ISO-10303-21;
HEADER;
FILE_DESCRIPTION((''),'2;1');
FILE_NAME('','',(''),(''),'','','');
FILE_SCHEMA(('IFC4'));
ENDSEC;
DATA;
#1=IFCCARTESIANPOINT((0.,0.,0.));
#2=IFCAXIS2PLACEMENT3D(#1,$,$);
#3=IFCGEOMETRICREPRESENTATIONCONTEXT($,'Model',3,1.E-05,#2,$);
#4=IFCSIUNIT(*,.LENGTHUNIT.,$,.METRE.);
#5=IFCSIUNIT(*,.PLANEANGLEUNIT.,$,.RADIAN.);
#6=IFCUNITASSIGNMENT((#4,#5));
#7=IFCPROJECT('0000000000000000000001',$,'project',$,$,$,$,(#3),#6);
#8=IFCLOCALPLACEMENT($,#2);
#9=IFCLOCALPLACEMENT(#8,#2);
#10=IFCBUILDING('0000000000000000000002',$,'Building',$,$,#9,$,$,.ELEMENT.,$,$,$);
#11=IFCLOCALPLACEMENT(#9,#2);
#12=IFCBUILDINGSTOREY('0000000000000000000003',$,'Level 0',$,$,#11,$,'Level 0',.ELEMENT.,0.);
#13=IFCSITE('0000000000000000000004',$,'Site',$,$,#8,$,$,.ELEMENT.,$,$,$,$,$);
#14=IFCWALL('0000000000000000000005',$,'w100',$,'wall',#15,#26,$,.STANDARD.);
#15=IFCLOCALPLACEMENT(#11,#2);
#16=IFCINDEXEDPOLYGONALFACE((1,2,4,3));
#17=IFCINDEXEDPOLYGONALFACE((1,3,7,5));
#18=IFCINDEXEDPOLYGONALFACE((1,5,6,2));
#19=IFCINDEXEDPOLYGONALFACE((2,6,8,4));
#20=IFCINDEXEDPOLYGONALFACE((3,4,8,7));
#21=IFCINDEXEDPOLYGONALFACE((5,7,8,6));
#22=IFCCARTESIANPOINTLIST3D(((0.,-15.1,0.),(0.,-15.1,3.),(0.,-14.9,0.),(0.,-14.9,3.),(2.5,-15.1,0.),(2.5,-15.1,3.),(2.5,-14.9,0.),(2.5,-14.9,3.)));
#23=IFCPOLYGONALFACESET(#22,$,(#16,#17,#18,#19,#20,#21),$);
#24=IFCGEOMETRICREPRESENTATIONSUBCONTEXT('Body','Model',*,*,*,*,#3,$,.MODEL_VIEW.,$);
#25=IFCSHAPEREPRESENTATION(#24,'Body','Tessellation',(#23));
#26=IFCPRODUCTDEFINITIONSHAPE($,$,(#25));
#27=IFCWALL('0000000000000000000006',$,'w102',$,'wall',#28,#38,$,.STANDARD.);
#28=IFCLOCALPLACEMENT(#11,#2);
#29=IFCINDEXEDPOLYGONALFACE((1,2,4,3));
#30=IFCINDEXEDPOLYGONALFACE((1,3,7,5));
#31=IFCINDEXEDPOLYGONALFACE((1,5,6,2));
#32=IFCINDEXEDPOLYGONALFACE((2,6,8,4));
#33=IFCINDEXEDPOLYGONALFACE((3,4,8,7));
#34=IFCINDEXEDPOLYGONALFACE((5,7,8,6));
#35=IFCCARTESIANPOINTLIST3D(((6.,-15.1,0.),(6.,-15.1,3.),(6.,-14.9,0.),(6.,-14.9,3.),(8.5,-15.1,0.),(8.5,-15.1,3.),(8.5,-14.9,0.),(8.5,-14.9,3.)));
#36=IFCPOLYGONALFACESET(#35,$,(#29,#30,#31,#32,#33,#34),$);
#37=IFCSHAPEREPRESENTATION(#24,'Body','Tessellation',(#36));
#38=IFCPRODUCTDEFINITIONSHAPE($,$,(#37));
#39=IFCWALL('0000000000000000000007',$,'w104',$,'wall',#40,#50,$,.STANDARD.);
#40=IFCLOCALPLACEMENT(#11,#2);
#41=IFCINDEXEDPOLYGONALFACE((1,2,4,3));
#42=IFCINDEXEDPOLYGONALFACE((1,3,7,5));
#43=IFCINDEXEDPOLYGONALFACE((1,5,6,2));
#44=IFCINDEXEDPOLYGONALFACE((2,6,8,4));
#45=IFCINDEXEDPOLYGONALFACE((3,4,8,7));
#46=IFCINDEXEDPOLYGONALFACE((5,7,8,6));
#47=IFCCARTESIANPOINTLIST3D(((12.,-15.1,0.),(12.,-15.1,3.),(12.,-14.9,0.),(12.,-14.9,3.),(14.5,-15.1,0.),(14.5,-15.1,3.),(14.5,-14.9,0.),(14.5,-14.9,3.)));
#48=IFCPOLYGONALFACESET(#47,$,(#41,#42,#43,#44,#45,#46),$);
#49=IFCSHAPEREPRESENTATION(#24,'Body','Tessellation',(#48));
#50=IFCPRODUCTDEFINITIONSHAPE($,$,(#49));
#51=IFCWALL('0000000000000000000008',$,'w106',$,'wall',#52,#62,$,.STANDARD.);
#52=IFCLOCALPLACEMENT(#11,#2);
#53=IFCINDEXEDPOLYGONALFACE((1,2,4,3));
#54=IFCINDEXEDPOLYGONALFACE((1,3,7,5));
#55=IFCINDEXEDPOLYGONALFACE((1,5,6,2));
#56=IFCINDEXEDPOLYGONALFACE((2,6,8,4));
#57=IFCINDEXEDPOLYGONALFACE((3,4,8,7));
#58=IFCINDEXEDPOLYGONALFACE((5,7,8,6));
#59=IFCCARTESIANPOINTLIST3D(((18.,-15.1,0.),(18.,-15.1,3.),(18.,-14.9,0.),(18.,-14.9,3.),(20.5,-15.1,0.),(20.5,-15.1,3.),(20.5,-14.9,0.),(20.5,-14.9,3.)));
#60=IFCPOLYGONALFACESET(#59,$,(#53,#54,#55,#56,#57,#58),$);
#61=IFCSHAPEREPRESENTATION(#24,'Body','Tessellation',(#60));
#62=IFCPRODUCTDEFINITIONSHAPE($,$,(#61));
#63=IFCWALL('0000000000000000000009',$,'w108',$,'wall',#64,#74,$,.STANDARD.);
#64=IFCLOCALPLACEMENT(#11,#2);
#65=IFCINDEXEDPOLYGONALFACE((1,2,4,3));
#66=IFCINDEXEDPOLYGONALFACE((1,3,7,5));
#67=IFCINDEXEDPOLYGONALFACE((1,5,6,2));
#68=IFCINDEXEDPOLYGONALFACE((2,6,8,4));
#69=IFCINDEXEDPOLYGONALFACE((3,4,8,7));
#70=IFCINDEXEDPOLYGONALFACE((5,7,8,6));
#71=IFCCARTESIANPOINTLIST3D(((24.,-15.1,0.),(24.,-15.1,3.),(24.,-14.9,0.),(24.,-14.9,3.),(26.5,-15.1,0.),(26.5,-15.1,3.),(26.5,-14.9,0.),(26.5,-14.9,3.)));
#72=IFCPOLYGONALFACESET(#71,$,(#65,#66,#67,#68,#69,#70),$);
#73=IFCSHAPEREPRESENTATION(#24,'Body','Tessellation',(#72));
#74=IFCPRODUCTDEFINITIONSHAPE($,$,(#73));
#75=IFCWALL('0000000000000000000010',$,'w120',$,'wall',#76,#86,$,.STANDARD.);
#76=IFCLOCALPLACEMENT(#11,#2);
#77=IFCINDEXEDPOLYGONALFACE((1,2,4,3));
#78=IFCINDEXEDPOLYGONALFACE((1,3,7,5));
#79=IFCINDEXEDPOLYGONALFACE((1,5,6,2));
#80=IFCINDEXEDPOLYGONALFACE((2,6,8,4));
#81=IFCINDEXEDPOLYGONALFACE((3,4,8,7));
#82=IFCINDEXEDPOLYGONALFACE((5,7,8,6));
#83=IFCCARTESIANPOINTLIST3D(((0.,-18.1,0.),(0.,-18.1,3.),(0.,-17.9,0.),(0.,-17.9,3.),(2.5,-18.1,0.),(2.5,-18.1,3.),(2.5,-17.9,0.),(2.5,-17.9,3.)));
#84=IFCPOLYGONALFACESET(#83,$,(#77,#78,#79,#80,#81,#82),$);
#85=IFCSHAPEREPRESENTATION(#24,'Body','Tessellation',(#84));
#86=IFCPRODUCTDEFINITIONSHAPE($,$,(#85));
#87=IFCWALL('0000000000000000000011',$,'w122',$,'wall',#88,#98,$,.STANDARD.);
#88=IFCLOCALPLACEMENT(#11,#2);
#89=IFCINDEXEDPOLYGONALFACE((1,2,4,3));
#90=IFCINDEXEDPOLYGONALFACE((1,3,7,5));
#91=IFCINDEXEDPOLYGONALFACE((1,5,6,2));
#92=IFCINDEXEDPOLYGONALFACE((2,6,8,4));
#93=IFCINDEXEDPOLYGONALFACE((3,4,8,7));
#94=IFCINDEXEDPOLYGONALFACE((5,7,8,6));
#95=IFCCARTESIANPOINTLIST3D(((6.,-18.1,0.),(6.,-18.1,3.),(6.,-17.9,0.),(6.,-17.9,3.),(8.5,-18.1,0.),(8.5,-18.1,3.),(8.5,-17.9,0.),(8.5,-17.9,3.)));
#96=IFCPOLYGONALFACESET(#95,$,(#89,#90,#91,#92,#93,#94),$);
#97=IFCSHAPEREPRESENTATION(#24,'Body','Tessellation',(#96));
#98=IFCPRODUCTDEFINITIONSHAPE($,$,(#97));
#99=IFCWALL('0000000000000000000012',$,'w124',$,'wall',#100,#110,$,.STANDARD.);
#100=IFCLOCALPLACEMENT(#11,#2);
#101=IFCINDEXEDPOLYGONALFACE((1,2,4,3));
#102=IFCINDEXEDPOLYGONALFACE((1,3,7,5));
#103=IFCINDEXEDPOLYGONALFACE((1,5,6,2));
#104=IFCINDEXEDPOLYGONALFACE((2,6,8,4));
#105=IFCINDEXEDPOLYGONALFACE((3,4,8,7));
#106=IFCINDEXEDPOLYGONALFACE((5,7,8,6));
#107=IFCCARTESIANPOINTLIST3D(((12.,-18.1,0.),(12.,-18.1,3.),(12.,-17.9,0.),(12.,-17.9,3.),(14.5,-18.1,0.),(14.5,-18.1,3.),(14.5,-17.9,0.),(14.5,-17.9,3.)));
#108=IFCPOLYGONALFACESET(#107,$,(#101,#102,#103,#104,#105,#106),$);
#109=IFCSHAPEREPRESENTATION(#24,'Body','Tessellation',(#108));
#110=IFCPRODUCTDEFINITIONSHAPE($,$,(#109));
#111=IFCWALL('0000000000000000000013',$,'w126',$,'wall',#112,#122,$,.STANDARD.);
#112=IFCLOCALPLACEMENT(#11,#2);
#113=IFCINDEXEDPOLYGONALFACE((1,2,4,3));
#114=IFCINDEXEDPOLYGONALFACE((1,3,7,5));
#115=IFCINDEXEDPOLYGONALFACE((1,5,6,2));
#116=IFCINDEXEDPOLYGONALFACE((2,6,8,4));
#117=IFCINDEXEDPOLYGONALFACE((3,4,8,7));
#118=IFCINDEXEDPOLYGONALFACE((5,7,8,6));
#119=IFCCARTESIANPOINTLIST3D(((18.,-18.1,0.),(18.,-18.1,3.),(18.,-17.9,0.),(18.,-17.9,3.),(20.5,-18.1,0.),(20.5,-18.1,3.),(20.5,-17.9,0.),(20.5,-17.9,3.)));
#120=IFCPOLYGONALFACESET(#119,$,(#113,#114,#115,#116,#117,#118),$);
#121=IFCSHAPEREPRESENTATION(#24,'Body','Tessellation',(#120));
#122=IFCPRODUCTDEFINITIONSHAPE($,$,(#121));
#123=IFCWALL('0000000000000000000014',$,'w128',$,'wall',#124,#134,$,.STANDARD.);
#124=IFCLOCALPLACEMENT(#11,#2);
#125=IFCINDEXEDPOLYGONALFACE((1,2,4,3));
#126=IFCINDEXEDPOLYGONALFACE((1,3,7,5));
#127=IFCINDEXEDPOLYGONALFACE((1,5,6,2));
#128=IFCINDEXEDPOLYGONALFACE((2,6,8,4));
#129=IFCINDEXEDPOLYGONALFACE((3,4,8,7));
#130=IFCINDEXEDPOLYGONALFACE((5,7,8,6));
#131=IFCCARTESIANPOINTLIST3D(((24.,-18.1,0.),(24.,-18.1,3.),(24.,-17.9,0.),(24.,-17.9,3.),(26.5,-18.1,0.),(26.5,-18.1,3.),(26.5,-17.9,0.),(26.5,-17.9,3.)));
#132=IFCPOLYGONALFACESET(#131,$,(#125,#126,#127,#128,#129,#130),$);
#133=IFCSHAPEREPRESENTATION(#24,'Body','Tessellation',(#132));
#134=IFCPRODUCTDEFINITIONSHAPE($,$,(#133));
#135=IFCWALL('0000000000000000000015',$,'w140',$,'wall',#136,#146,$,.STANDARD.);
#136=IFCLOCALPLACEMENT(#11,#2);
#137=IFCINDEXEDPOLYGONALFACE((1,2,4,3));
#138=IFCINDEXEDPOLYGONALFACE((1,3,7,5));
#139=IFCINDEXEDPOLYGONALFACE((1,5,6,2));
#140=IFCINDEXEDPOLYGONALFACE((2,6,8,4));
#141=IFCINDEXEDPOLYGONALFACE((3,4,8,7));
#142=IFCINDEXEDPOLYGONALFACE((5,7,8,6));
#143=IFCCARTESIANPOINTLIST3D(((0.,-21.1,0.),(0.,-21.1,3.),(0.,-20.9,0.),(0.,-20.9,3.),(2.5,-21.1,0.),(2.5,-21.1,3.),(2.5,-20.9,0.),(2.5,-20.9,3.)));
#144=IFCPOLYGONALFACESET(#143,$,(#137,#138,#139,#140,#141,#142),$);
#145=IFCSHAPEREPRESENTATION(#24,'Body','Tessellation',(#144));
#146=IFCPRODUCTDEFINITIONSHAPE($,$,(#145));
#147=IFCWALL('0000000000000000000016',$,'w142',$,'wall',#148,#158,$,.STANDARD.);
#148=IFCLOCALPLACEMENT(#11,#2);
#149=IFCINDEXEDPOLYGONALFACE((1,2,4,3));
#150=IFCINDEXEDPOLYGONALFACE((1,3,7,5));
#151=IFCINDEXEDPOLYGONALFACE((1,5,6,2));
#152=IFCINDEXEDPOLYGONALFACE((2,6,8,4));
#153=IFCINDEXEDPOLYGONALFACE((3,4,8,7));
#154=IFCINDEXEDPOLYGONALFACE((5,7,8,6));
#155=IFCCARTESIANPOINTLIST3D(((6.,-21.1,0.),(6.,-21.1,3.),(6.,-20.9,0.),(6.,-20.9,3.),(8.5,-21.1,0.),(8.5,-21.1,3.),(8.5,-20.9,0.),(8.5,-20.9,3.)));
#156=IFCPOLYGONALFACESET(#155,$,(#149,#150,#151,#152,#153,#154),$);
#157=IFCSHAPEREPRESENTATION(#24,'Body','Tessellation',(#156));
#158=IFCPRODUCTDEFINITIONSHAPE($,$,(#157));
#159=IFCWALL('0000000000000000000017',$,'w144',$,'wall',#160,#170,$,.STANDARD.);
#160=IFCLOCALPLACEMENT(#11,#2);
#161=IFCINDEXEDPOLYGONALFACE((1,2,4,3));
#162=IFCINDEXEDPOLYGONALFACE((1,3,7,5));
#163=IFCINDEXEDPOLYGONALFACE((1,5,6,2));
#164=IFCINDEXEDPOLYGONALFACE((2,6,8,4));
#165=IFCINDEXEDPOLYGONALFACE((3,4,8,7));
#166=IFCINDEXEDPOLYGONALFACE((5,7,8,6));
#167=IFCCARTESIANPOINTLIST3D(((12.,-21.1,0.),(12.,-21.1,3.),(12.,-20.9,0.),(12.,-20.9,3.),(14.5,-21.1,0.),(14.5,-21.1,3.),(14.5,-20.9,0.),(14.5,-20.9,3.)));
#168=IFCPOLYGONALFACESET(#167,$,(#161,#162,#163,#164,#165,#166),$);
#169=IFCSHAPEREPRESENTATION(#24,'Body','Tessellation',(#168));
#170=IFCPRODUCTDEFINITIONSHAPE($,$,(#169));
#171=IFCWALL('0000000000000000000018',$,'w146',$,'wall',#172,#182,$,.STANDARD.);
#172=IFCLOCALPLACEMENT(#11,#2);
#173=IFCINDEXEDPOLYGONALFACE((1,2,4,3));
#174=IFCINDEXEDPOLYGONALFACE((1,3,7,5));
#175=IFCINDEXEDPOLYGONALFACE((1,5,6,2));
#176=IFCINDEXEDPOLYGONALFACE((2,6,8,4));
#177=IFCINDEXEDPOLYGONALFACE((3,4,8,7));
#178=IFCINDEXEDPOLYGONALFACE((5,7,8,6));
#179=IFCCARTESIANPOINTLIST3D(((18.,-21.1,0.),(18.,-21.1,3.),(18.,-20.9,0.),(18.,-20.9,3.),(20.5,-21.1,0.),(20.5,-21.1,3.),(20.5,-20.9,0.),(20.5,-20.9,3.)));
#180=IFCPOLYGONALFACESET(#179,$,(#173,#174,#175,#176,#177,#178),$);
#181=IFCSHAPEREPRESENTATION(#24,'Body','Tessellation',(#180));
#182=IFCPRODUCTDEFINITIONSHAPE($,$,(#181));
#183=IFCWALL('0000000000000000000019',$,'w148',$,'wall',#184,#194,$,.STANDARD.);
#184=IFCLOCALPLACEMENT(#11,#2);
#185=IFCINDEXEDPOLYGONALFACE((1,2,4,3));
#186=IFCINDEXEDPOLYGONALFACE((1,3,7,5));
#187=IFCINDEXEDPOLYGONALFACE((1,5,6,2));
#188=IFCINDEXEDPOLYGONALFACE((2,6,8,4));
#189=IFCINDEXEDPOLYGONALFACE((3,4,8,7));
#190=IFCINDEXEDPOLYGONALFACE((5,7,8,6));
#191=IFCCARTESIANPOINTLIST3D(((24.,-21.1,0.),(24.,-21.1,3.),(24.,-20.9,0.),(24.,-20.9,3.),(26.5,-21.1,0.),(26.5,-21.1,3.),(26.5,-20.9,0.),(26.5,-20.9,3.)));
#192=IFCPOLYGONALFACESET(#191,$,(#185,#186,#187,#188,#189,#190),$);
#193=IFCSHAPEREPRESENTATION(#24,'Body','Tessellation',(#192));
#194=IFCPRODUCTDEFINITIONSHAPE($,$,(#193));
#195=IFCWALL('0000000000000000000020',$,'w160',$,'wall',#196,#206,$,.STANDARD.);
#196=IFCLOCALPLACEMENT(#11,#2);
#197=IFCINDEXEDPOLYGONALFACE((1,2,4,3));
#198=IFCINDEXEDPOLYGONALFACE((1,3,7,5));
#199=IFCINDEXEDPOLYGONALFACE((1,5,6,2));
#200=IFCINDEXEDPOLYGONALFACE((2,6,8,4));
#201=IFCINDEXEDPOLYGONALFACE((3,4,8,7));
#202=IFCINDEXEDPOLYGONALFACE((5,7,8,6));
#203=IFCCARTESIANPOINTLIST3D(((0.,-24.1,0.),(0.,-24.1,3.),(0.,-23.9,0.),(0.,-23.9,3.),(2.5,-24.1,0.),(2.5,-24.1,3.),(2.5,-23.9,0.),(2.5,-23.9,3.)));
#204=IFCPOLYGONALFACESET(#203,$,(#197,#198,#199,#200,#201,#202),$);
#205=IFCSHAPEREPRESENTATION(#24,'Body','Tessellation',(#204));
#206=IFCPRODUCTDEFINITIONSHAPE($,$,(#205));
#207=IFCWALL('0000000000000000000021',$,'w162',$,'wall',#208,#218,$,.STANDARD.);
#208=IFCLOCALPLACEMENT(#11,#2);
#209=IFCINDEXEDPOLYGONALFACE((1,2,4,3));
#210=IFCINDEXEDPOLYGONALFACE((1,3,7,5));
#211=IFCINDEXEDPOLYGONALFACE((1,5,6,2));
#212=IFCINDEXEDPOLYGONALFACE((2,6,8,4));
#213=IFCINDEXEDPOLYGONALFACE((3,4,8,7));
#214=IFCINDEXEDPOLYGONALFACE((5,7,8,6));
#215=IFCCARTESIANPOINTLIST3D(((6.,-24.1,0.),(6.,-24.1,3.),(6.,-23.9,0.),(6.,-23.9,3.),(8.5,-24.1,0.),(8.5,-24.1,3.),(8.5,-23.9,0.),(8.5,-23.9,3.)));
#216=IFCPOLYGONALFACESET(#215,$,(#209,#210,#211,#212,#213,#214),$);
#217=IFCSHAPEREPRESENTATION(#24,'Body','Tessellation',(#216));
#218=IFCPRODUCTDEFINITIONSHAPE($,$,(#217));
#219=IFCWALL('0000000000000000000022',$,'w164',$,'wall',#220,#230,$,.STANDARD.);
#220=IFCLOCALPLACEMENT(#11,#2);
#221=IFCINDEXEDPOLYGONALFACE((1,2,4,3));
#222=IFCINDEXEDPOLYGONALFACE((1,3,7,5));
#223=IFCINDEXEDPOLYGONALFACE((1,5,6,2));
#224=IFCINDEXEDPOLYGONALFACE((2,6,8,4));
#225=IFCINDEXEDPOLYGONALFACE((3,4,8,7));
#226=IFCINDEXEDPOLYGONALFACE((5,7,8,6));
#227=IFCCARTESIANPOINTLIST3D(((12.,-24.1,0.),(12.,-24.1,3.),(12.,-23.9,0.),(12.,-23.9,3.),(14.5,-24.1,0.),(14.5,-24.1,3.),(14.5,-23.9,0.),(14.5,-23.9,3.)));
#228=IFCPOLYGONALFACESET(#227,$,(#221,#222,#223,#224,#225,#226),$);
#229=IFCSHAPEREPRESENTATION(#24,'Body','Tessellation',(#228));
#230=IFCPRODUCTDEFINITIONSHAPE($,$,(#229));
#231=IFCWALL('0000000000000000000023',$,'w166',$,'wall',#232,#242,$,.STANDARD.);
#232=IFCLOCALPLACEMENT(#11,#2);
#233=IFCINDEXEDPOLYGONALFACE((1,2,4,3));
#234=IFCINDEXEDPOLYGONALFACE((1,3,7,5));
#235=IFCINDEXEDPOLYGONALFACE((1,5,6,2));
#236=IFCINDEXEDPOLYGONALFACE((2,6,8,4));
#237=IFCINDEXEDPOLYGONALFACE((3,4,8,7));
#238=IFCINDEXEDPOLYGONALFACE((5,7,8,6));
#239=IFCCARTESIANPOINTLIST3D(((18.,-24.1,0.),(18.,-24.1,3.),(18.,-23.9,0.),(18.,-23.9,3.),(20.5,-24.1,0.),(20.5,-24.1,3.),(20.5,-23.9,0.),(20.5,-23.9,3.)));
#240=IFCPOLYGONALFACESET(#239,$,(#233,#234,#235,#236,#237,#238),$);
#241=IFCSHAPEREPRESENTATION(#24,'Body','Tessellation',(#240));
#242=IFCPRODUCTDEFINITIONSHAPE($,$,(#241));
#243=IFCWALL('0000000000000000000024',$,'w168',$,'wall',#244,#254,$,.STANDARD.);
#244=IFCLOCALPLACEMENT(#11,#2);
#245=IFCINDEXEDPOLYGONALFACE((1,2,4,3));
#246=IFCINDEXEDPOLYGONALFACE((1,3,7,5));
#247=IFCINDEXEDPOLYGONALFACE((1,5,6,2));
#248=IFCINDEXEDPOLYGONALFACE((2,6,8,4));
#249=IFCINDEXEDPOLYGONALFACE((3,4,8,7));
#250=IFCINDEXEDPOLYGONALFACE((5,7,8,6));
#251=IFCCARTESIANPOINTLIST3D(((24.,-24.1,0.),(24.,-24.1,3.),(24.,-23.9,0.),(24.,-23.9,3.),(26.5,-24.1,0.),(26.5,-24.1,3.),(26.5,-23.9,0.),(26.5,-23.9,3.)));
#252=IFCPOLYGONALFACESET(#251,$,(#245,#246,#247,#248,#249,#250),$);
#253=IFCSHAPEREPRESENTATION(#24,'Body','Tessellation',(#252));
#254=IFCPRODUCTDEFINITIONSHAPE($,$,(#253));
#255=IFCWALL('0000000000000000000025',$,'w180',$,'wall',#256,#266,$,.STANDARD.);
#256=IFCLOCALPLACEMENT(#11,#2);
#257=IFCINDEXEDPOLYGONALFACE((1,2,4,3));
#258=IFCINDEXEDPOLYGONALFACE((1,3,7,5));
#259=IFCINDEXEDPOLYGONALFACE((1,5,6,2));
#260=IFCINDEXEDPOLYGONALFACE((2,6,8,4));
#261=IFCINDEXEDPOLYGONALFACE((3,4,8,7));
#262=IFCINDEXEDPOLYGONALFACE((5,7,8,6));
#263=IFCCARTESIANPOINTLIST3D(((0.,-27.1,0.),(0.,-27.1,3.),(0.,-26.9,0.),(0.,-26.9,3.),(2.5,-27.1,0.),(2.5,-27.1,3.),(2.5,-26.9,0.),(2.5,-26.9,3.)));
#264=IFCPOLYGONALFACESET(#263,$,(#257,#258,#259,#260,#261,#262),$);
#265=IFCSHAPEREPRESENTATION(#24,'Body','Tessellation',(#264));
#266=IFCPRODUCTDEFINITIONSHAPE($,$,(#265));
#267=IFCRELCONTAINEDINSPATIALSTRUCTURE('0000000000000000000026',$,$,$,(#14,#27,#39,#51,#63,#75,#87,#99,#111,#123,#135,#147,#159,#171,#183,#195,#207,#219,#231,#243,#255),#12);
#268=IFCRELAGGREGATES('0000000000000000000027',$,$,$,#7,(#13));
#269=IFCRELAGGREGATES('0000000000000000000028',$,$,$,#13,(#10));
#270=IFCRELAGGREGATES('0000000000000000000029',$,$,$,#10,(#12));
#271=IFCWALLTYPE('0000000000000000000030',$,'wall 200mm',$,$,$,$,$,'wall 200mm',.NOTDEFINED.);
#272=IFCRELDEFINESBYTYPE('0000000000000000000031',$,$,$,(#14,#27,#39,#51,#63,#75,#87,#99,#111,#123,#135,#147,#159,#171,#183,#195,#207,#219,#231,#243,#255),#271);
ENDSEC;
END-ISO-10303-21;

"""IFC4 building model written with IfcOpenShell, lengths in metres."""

from ifc_helpers import new_model, si_unit, frame, frame_2d, origin, place, context, subcontext, project, spatial, rectangle, extrude, type_object, element, save


model = new_model("IFC4")

# Units and contexts
model_context = context("Model", 3, precision=1e-05, world=origin())
body_context = subcontext(model_context, "Body", "Model", "MODEL_VIEW")
ifc_project = project(units=[si_unit("LENGTHUNIT", "METRE"), si_unit("PLANEANGLEUNIT", "RADIAN")], contexts=[model_context])

# Site, building, storey
site_placement = place(None, origin())
site = spatial("IfcSite", under=ifc_project, at=site_placement, Name="Site", CompositionType="ELEMENT")
building_placement = place(site_placement, origin())
building = spatial("IfcBuilding", under=site, at=building_placement, Name="Building", CompositionType="ELEMENT")
storey_placement = place(building_placement, origin())
storey = spatial("IfcBuildingStorey", under=building, at=storey_placement, Name="Level 0", LongName="Level 0", CompositionType="ELEMENT", Elevation=0.0)

# Walls
wall_type = type_object("IfcWallType", Name="wall 200mm", ElementType="wall 200mm", PredefinedType="NOTDEFINED")
for number, where, z_axis, x_axis, name in (
    (1, (0.0, -15.0, 0.0), (0.0, 0.0, 1.0), (1.0, 0.0, 0.0), "w100"),
    (2, (6.0, -15.0, 0.0), (0.0, 0.0, 1.0), (1.0, 0.0, 0.0), "w102"),
    (3, (12.0, -15.0, 0.0), (0.0, 0.0, 1.0), (1.0, 0.0, 0.0), "w104"),
    (4, (18.0, -15.0, 0.0), (0.0, 0.0, 1.0), (1.0, 0.0, 0.0), "w106"),
    (5, (24.0, -15.0, 0.0), (0.0, 0.0, 1.0), (1.0, 0.0, 0.0), "w108"),
    (6, (0.0, -18.0, 0.0), (0.0, 0.0, 1.0), (1.0, 0.0, 0.0), "w120"),
    (7, (6.0, -18.0, 0.0), (0.0, 0.0, 1.0), (1.0, 0.0, 0.0), "w122"),
    (8, (12.0, -18.0, 0.0), (0.0, 0.0, 1.0), (1.0, 0.0, 0.0), "w124"),
    (9, (18.0, -18.0, 0.0), (0.0, 0.0, 1.0), (1.0, 0.0, 0.0), "w126"),
    (10, (24.0, -18.0, 0.0), (0.0, 0.0, 1.0), (1.0, 0.0, 0.0), "w128"),
    (11, (0.0, -21.0, 0.0), (0.0, 0.0, 1.0), (1.0, 0.0, 0.0), "w140"),
    (12, (6.0, -21.0, 0.0), (0.0, 0.0, 1.0), (1.0, 0.0, 0.0), "w142"),
    (13, (12.0, -21.0, 0.0), (0.0, 0.0, 1.0), (1.0, 0.0, 0.0), "w144"),
    (14, (18.0, -21.0, 0.0), (0.0, 0.0, 1.0), (1.0, 0.0, 0.0), "w146"),
    (15, (24.0, -21.0, 0.0), (0.0, 0.0, 1.0), (1.0, 0.0, 0.0), "w148"),
    (16, (0.0, -24.0, 0.0), (0.0, 0.0, 1.0), (1.0, 0.0, 0.0), "w160"),
    (17, (6.0, -24.0, 0.0), (0.0, 0.0, 1.0), (1.0, 0.0, 0.0), "w162"),
    (18, (12.0, -24.0, 0.0), (0.0, 0.0, 1.0), (1.0, 0.0, 0.0), "w164"),
    (19, (18.0, -24.0, 0.0), (0.0, 0.0, 1.0), (1.0, 0.0, 0.0), "w166"),
    (20, (24.0, -24.0, 0.0), (0.0, 0.0, 1.0), (1.0, 0.0, 0.0), "w168"),
    (21, (0.0, -27.0, 0.0), (0.0, 0.0, 1.0), (1.0, 0.0, 0.0), "w180"),
):
    element("IfcWall", number, at=place(storey_placement, frame(where, z_axis=z_axis, x_axis=x_axis)), inside=storey, type_object=wall_type, Name=name, ObjectType="wall", PredefinedType="STANDARD", context=body_context, shape_type="SweptSolid", body=[
        extrude(rectangle(XDim=2.5, YDim=0.2, at=frame_2d((1.25, 0.0))), origin(), (0.0, 0.0, 1.0), 3.0),
    ])

save(model, "model.ifc")
